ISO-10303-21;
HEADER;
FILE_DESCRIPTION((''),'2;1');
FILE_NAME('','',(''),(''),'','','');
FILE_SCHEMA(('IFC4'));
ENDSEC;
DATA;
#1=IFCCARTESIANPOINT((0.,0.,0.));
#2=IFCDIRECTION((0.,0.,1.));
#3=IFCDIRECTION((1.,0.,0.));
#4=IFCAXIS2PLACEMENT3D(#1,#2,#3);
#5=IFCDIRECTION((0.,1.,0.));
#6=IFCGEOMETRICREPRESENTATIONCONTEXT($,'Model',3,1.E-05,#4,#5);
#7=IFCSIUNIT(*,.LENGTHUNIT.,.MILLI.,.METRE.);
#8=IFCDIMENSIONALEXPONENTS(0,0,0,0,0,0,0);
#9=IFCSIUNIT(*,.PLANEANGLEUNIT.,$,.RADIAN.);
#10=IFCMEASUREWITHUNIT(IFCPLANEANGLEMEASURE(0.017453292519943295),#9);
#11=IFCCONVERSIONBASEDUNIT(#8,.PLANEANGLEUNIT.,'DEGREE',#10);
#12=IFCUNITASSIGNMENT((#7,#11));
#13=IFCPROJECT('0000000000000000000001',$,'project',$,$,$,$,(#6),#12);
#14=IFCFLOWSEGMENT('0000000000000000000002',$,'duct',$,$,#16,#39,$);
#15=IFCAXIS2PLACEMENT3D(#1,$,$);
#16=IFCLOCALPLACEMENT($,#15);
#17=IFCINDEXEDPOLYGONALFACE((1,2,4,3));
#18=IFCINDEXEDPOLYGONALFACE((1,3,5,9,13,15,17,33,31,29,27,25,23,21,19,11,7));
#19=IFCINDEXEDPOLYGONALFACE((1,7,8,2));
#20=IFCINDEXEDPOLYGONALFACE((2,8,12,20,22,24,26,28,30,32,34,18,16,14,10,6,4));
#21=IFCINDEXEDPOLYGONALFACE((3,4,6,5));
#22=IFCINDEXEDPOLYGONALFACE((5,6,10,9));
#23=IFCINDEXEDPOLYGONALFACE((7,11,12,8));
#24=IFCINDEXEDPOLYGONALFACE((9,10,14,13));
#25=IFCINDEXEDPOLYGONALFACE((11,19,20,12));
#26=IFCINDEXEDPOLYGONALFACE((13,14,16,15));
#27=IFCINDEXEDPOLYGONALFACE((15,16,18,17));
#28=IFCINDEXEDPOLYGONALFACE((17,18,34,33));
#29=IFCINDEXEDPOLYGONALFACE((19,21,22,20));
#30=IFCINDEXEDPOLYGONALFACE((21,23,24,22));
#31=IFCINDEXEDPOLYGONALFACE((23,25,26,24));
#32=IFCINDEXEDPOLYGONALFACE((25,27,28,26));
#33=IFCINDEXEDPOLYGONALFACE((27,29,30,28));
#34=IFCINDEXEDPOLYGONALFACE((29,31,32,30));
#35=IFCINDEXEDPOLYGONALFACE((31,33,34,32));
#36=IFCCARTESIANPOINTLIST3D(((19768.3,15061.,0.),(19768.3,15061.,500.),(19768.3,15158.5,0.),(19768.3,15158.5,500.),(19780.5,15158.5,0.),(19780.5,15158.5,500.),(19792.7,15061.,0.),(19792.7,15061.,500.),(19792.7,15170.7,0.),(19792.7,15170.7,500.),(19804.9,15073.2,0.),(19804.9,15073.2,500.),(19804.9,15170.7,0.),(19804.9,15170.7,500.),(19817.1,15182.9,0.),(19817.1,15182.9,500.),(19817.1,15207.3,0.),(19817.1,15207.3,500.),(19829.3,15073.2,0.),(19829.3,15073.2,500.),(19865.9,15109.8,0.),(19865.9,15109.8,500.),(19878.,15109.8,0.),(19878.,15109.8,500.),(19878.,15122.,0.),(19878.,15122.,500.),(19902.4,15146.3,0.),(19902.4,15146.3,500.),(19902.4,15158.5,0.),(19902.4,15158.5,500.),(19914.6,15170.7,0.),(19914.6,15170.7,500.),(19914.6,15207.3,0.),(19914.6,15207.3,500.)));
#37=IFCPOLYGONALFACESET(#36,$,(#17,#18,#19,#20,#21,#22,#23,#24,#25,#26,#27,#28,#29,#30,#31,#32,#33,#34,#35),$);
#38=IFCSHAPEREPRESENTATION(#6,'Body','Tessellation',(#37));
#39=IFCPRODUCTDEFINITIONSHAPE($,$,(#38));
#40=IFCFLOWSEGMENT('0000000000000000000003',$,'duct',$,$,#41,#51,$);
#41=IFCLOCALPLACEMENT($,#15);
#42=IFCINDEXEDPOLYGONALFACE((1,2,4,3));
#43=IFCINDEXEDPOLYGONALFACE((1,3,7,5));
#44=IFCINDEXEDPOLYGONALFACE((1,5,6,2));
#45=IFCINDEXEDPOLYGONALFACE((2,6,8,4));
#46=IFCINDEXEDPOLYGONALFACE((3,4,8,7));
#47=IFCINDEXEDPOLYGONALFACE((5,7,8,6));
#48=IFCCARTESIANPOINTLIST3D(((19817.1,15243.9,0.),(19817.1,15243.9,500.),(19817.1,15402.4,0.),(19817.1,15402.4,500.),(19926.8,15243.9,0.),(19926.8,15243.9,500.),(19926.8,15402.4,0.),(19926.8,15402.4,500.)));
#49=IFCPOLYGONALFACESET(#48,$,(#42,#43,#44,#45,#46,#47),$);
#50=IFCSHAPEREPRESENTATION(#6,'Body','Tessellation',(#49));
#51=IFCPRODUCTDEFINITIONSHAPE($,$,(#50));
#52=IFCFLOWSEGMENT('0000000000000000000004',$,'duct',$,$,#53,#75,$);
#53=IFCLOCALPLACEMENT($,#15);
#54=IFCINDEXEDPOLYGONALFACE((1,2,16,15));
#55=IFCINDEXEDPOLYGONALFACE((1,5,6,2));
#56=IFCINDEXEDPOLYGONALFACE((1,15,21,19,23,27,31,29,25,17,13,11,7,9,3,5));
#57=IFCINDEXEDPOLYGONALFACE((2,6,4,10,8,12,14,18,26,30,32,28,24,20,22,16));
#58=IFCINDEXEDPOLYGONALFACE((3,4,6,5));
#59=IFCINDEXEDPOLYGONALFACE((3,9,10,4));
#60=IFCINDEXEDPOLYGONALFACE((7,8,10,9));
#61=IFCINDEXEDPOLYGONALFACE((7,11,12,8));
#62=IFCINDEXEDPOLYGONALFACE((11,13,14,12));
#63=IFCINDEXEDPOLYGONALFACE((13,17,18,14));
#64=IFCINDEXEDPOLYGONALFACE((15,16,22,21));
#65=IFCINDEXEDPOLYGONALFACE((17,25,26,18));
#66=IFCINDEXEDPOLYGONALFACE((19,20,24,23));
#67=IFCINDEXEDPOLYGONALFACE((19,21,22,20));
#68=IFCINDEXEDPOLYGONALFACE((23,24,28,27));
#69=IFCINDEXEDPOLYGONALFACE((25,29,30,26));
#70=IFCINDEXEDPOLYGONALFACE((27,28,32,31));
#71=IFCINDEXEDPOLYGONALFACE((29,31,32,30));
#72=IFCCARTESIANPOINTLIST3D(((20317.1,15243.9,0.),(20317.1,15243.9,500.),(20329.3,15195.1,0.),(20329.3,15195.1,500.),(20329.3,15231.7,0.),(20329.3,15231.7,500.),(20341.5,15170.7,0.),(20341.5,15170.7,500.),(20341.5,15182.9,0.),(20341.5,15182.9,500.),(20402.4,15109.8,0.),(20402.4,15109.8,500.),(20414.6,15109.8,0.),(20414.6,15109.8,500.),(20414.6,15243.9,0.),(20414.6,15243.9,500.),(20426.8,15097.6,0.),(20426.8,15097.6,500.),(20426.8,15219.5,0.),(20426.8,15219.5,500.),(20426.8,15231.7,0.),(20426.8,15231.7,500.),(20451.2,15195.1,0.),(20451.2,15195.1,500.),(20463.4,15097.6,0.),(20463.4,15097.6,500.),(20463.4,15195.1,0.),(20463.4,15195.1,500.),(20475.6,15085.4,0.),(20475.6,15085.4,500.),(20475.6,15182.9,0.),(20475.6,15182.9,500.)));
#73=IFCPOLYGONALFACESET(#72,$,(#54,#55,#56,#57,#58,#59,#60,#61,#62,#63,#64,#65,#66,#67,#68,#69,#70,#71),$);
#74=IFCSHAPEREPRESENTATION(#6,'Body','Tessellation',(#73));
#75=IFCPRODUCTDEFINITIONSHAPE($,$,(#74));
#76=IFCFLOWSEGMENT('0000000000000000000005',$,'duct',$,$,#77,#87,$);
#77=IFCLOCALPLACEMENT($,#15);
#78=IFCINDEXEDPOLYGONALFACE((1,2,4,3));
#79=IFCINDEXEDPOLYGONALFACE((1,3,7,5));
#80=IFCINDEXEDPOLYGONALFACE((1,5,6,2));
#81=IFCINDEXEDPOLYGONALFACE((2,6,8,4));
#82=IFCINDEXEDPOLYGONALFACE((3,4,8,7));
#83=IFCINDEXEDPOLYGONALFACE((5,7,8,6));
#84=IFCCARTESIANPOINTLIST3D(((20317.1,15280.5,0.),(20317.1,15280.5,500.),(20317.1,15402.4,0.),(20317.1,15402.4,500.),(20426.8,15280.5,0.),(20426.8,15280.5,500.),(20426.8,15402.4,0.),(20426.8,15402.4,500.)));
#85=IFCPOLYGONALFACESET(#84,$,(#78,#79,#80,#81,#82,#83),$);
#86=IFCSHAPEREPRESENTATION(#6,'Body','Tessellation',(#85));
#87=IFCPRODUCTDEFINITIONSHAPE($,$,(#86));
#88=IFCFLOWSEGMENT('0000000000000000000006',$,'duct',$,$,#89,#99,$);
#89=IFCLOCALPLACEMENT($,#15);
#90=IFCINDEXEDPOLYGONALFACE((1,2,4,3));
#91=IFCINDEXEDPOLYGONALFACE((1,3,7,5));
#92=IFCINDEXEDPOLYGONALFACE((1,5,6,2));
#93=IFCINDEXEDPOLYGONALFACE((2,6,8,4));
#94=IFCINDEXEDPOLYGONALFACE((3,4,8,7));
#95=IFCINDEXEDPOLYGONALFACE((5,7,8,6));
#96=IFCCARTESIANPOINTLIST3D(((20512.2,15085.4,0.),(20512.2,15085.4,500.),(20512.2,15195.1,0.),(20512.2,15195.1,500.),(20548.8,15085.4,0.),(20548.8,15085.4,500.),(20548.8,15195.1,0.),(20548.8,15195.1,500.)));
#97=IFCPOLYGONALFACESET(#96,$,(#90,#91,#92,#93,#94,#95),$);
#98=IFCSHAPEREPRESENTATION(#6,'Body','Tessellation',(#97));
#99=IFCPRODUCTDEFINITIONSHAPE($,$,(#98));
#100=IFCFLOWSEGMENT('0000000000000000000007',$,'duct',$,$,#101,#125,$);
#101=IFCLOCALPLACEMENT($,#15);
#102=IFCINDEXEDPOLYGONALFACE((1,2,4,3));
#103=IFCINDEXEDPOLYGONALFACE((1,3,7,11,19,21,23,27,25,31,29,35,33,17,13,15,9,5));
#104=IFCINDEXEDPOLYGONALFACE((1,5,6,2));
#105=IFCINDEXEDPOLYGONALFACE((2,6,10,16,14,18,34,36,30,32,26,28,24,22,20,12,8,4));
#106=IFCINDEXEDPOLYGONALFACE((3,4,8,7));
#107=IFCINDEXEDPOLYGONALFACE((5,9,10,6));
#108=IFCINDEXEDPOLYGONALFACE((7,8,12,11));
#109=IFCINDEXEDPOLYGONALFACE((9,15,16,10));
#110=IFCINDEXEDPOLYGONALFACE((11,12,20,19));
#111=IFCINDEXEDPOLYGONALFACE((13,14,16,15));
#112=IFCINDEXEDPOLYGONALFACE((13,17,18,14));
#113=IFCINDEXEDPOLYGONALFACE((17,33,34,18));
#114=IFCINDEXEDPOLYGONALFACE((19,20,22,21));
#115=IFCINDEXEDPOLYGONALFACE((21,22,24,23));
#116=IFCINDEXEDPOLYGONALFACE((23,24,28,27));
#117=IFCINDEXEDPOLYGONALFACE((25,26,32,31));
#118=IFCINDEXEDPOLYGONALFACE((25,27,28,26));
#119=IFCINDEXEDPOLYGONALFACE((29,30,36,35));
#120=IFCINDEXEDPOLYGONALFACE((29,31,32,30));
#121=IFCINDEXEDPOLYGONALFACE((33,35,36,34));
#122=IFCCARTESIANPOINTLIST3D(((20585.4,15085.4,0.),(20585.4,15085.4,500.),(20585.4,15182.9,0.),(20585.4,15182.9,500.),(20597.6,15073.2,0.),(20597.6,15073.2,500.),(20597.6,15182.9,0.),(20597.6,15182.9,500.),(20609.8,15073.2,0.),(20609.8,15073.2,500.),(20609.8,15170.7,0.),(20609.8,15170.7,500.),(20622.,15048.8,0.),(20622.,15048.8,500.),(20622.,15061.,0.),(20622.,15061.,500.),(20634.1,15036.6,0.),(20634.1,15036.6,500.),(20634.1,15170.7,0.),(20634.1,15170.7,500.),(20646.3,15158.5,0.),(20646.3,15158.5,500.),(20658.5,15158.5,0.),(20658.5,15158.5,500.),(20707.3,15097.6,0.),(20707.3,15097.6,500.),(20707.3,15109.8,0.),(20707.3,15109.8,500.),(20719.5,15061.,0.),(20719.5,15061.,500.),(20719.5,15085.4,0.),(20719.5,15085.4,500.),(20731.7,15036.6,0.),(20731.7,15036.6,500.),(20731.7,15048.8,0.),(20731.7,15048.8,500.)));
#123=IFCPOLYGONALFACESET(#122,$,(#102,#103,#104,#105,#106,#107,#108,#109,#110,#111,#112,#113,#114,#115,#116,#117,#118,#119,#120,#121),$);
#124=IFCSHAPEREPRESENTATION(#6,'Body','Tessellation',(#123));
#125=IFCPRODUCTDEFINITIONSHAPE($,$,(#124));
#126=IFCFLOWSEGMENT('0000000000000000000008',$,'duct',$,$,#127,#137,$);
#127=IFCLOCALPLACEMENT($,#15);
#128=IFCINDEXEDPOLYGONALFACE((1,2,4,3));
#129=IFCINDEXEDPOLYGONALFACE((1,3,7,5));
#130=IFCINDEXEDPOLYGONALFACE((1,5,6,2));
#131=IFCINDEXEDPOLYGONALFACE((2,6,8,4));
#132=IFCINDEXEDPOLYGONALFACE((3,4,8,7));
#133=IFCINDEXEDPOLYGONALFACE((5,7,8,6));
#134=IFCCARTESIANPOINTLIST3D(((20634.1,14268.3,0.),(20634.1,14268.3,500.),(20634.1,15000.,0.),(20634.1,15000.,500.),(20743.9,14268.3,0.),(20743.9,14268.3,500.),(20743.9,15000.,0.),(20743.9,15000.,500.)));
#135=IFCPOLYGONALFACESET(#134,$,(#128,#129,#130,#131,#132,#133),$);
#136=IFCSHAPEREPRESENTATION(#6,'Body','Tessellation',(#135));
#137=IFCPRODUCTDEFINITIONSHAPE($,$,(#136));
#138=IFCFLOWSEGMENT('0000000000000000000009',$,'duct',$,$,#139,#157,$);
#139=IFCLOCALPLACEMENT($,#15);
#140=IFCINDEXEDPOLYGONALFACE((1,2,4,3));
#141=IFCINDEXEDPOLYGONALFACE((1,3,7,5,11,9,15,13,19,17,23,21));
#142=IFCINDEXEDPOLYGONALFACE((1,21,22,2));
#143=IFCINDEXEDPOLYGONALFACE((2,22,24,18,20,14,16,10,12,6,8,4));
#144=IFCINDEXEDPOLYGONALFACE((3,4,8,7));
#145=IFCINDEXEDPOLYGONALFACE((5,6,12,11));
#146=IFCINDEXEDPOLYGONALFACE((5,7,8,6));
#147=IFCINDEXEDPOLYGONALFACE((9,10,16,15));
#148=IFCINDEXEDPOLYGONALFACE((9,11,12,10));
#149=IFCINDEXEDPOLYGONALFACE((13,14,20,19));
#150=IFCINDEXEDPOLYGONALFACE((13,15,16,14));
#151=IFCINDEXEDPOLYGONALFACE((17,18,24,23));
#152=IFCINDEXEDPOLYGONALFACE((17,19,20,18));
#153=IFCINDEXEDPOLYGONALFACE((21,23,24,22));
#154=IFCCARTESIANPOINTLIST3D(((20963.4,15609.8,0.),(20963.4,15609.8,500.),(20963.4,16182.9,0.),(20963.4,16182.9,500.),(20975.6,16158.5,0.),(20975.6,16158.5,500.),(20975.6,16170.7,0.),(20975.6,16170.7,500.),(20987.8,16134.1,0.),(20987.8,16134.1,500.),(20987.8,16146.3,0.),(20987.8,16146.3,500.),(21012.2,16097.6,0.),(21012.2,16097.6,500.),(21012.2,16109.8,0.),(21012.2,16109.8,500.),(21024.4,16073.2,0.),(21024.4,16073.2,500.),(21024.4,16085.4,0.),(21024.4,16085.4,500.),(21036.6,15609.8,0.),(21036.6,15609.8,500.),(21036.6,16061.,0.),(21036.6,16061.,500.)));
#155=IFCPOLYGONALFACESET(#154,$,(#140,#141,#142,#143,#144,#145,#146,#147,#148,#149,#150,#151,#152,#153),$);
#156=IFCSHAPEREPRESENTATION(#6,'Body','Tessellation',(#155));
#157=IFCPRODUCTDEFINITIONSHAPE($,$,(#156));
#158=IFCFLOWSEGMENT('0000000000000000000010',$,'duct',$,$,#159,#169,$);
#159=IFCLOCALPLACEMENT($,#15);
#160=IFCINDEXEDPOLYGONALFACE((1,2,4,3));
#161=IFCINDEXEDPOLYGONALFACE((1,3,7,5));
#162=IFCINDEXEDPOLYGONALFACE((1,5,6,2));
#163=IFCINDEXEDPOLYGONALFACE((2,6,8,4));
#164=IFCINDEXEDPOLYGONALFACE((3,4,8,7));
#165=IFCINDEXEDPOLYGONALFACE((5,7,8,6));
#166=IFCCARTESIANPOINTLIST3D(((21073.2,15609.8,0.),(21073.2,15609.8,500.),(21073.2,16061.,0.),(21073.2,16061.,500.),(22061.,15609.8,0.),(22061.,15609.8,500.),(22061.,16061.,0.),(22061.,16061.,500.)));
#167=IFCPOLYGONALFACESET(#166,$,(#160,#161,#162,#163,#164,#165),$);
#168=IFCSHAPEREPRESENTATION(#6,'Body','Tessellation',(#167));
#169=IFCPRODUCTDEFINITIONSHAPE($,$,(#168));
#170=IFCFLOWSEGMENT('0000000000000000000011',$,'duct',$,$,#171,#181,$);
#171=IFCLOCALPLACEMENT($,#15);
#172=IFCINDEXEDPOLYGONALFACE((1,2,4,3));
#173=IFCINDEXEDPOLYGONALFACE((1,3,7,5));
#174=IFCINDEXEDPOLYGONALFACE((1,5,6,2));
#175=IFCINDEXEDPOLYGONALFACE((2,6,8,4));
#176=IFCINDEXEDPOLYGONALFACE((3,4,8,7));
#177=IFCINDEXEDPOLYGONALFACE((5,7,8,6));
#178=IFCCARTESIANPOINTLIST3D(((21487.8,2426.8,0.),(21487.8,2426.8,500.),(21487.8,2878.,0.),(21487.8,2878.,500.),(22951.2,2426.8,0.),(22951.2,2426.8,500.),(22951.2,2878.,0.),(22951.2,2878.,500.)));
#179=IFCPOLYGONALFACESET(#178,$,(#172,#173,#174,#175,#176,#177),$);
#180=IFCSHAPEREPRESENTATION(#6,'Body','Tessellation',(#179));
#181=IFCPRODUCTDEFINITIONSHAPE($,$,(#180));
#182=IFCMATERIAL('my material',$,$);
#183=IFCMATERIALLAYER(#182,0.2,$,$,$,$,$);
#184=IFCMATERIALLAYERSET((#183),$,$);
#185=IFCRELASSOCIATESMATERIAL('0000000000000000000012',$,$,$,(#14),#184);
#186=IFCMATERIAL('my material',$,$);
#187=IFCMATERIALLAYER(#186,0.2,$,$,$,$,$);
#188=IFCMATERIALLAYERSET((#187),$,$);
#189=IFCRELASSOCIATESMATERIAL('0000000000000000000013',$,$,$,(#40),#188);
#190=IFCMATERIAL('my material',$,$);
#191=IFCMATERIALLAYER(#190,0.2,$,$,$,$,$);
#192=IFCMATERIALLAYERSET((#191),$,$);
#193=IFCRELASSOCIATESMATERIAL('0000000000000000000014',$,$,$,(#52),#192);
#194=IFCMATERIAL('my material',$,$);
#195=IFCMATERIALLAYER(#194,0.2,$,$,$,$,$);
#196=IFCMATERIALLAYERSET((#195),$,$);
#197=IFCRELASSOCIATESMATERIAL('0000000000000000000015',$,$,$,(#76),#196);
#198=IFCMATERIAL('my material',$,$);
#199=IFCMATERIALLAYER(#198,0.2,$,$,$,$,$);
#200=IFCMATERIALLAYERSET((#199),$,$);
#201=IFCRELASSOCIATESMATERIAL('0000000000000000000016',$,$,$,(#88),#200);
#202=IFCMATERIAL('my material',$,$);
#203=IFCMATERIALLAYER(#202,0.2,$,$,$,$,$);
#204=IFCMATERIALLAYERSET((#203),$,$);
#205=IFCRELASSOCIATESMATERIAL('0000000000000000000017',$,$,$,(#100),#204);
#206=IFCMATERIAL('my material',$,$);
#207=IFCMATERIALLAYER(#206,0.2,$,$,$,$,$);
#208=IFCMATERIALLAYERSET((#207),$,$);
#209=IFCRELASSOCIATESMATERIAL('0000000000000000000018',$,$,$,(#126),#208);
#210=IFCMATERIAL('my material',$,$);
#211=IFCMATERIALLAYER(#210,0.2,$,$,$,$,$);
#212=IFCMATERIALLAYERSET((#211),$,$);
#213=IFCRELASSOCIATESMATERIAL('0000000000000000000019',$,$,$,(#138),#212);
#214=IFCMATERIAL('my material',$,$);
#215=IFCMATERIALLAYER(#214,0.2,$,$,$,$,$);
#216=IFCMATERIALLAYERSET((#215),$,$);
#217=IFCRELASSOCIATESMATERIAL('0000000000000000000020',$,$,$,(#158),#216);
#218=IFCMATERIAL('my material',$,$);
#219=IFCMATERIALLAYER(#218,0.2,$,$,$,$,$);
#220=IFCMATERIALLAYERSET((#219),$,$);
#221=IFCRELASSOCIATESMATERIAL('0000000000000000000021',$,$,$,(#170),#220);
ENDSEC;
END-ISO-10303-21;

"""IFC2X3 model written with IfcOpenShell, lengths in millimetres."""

from ifc_helpers import new_model, entity, si_unit, converted_unit, direction, origin_with_axes, place, context, project, polyline, outline, extrude, material, layer, layer_set, layer_usage, element, save


model = new_model("IFC2X3")

# Units and contexts
model_context = context("Model", 3, precision=1e-05, world=origin_with_axes(), true_north=direction((0.0, 1.0, 0.0)))
ifc_project = project(units=[si_unit("LENGTHUNIT", "METRE", prefix="MILLI"), converted_unit("PLANEANGLEUNIT", "DEGREE", entity("IfcPlaneAngleMeasure", 0.017453292519943295), si_unit("PLANEANGLEUNIT", "RADIAN"), dimensions=[0, 0, 0, 0, 0, 0, 0])], contexts=[model_context])

# Flow segments
ifc_material_1 = material(Name="my material")
ifc_layer_1 = layer(ifc_material_1, 0.2)
ifc_layer_set_1 = layer_set([ifc_layer_1])
ifc_layer_usage_1 = layer_usage(ifc_layer_set_1, "AXIS2", "POSITIVE", -0.1)
flow_segment_1_placement = place(None, origin_with_axes())
element("IfcFlowSegment", 1, at=flow_segment_1_placement, material=ifc_layer_usage_1, Name="duct", context=model_context, shape_type="SweptSolid", body=[
    extrude(outline(polyline([(19768.3, 15061.0), (19792.7, 15061.0), (19804.9, 15073.2), (19829.3, 15073.2), (19865.9, 15109.8), (19878.0, 15109.8), (19878.0, 15122.0), (19902.4, 15146.3), (19902.4, 15158.5), (19914.6, 15170.7), (19914.6, 15207.3), (19817.1, 15207.3), (19817.1, 15182.9), (19804.9, 15170.7), (19792.7, 15170.7), (19780.5, 15158.5), (19768.3, 15158.5), (19768.3, 15061.0)])), origin_with_axes(), (0.0, 0.0, 1.0), 500.0),
])
ifc_material_2 = material(Name="my material")
ifc_layer_2 = layer(ifc_material_2, 0.2)
ifc_layer_set_2 = layer_set([ifc_layer_2])
ifc_layer_usage_2 = layer_usage(ifc_layer_set_2, "AXIS2", "POSITIVE", -0.1)
flow_segment_2_placement = place(None, origin_with_axes())
element("IfcFlowSegment", 2, at=flow_segment_2_placement, material=ifc_layer_usage_2, Name="duct", context=model_context, shape_type="SweptSolid", body=[
    extrude(outline(polyline([(19817.1, 15243.9), (19926.8, 15243.9), (19926.8, 15402.4), (19817.1, 15402.4), (19817.1, 15243.9)])), origin_with_axes(), (0.0, 0.0, 1.0), 500.0),
])
ifc_material_3 = material(Name="my material")
ifc_layer_3 = layer(ifc_material_3, 0.2)
ifc_layer_set_3 = layer_set([ifc_layer_3])
ifc_layer_usage_3 = layer_usage(ifc_layer_set_3, "AXIS2", "POSITIVE", -0.1)
flow_segment_3_placement = place(None, origin_with_axes())
element("IfcFlowSegment", 3, at=flow_segment_3_placement, material=ifc_layer_usage_3, Name="duct", context=model_context, shape_type="SweptSolid", body=[
    extrude(outline(polyline([(20317.1, 15243.9), (20329.3, 15231.7), (20329.3, 15195.1), (20341.5, 15182.9), (20341.5, 15170.7), (20402.4, 15109.8), (20414.6, 15109.8), (20426.8, 15097.6), (20463.4, 15097.6), (20475.6, 15085.4), (20475.6, 15182.9), (20463.4, 15195.1), (20451.2, 15195.1), (20426.8, 15219.5), (20426.8, 15231.7), (20414.6, 15243.9), (20317.1, 15243.9)])), origin_with_axes(), (0.0, 0.0, 1.0), 500.0),
])
ifc_material_4 = material(Name="my material")
ifc_layer_4 = layer(ifc_material_4, 0.2)
ifc_layer_set_4 = layer_set([ifc_layer_4])
ifc_layer_usage_4 = layer_usage(ifc_layer_set_4, "AXIS2", "POSITIVE", -0.1)
flow_segment_4_placement = place(None, origin_with_axes())
element("IfcFlowSegment", 4, at=flow_segment_4_placement, material=ifc_layer_usage_4, Name="duct", context=model_context, shape_type="SweptSolid", body=[
    extrude(outline(polyline([(20317.1, 15280.5), (20426.8, 15280.5), (20426.8, 15402.4), (20317.1, 15402.4), (20317.1, 15280.5)])), origin_with_axes(), (0.0, 0.0, 1.0), 500.0),
])
ifc_material_5 = material(Name="my material")
ifc_layer_5 = layer(ifc_material_5, 0.2)
ifc_layer_set_5 = layer_set([ifc_layer_5])
ifc_layer_usage_5 = layer_usage(ifc_layer_set_5, "AXIS2", "POSITIVE", -0.1)
flow_segment_5_placement = place(None, origin_with_axes())
element("IfcFlowSegment", 5, at=flow_segment_5_placement, material=ifc_layer_usage_5, Name="duct", context=model_context, shape_type="SweptSolid", body=[
    extrude(outline(polyline([(20512.2, 15085.4), (20548.8, 15085.4), (20548.8, 15195.1), (20512.2, 15195.1), (20512.2, 15085.4)])), origin_with_axes(), (0.0, 0.0, 1.0), 500.0),
])
ifc_material_6 = material(Name="my material")
ifc_layer_6 = layer(ifc_material_6, 0.2)
ifc_layer_set_6 = layer_set([ifc_layer_6])
ifc_layer_usage_6 = layer_usage(ifc_layer_set_6, "AXIS2", "POSITIVE", -0.1)
flow_segment_6_placement = place(None, origin_with_axes())
element("IfcFlowSegment", 6, at=flow_segment_6_placement, material=ifc_layer_usage_6, Name="duct", context=model_context, shape_type="SweptSolid", body=[
    extrude(outline(polyline([(20585.4, 15085.4), (20597.6, 15073.2), (20609.8, 15073.2), (20622.0, 15061.0), (20622.0, 15048.8), (20634.1, 15036.6), (20731.7, 15036.6), (20731.7, 15048.8), (20719.5, 15061.0), (20719.5, 15085.4), (20707.3, 15097.6), (20707.3, 15109.8), (20658.5, 15158.5), (20646.3, 15158.5), (20634.1, 15170.7), (20609.8, 15170.7), (20597.6, 15182.9), (20585.4, 15182.9), (20585.4, 15085.4)])), origin_with_axes(), (0.0, 0.0, 1.0), 500.0),
])
ifc_material_7 = material(Name="my material")
ifc_layer_7 = layer(ifc_material_7, 0.2)
ifc_layer_set_7 = layer_set([ifc_layer_7])
ifc_layer_usage_7 = layer_usage(ifc_layer_set_7, "AXIS2", "POSITIVE", -0.1)
flow_segment_7_placement = place(None, origin_with_axes())
element("IfcFlowSegment", 7, at=flow_segment_7_placement, material=ifc_layer_usage_7, Name="duct", context=model_context, shape_type="SweptSolid", body=[
    extrude(outline(polyline([(20634.1, 14268.3), (20743.9, 14268.3), (20743.9, 15000.0), (20634.1, 15000.0), (20634.1, 14268.3)])), origin_with_axes(), (0.0, 0.0, 1.0), 500.0),
])
ifc_material_8 = material(Name="my material")
ifc_layer_8 = layer(ifc_material_8, 0.2)
ifc_layer_set_8 = layer_set([ifc_layer_8])
ifc_layer_usage_8 = layer_usage(ifc_layer_set_8, "AXIS2", "POSITIVE", -0.1)
flow_segment_8_placement = place(None, origin_with_axes())
element("IfcFlowSegment", 8, at=flow_segment_8_placement, material=ifc_layer_usage_8, Name="duct", context=model_context, shape_type="SweptSolid", body=[
    extrude(outline(polyline([(20963.4, 15609.8), (21036.6, 15609.8), (21036.6, 16061.0), (21024.4, 16073.2), (21024.4, 16085.4), (21012.2, 16097.6), (21012.2, 16109.8), (20987.8, 16134.1), (20987.8, 16146.3), (20975.6, 16158.5), (20975.6, 16170.7), (20963.4, 16182.9), (20963.4, 16195.1), (20963.4, 15609.8)])), origin_with_axes(), (0.0, 0.0, 1.0), 500.0),
])
ifc_material_9 = material(Name="my material")
ifc_layer_9 = layer(ifc_material_9, 0.2)
ifc_layer_set_9 = layer_set([ifc_layer_9])
ifc_layer_usage_9 = layer_usage(ifc_layer_set_9, "AXIS2", "POSITIVE", -0.1)
flow_segment_9_placement = place(None, origin_with_axes())
element("IfcFlowSegment", 9, at=flow_segment_9_placement, material=ifc_layer_usage_9, Name="duct", context=model_context, shape_type="SweptSolid", body=[
    extrude(outline(polyline([(21073.2, 15609.8), (22061.0, 15609.8), (22061.0, 16061.0), (21073.2, 16061.0), (21073.2, 15609.8)])), origin_with_axes(), (0.0, 0.0, 1.0), 500.0),
])
ifc_material_10 = material(Name="my material")
ifc_layer_10 = layer(ifc_material_10, 0.2)
ifc_layer_set_10 = layer_set([ifc_layer_10])
ifc_layer_usage_10 = layer_usage(ifc_layer_set_10, "AXIS2", "POSITIVE", -0.1)
flow_segment_10_placement = place(None, origin_with_axes())
element("IfcFlowSegment", 10, at=flow_segment_10_placement, material=ifc_layer_usage_10, Name="duct", context=model_context, shape_type="SweptSolid", body=[
    extrude(outline(polyline([(21487.8, 2426.8), (22951.2, 2426.8), (22951.2, 2878.0), (21487.8, 2878.0), (21487.8, 2426.8)])), origin_with_axes(), (0.0, 0.0, 1.0), 500.0),
])

save(model, "model.ifc")
